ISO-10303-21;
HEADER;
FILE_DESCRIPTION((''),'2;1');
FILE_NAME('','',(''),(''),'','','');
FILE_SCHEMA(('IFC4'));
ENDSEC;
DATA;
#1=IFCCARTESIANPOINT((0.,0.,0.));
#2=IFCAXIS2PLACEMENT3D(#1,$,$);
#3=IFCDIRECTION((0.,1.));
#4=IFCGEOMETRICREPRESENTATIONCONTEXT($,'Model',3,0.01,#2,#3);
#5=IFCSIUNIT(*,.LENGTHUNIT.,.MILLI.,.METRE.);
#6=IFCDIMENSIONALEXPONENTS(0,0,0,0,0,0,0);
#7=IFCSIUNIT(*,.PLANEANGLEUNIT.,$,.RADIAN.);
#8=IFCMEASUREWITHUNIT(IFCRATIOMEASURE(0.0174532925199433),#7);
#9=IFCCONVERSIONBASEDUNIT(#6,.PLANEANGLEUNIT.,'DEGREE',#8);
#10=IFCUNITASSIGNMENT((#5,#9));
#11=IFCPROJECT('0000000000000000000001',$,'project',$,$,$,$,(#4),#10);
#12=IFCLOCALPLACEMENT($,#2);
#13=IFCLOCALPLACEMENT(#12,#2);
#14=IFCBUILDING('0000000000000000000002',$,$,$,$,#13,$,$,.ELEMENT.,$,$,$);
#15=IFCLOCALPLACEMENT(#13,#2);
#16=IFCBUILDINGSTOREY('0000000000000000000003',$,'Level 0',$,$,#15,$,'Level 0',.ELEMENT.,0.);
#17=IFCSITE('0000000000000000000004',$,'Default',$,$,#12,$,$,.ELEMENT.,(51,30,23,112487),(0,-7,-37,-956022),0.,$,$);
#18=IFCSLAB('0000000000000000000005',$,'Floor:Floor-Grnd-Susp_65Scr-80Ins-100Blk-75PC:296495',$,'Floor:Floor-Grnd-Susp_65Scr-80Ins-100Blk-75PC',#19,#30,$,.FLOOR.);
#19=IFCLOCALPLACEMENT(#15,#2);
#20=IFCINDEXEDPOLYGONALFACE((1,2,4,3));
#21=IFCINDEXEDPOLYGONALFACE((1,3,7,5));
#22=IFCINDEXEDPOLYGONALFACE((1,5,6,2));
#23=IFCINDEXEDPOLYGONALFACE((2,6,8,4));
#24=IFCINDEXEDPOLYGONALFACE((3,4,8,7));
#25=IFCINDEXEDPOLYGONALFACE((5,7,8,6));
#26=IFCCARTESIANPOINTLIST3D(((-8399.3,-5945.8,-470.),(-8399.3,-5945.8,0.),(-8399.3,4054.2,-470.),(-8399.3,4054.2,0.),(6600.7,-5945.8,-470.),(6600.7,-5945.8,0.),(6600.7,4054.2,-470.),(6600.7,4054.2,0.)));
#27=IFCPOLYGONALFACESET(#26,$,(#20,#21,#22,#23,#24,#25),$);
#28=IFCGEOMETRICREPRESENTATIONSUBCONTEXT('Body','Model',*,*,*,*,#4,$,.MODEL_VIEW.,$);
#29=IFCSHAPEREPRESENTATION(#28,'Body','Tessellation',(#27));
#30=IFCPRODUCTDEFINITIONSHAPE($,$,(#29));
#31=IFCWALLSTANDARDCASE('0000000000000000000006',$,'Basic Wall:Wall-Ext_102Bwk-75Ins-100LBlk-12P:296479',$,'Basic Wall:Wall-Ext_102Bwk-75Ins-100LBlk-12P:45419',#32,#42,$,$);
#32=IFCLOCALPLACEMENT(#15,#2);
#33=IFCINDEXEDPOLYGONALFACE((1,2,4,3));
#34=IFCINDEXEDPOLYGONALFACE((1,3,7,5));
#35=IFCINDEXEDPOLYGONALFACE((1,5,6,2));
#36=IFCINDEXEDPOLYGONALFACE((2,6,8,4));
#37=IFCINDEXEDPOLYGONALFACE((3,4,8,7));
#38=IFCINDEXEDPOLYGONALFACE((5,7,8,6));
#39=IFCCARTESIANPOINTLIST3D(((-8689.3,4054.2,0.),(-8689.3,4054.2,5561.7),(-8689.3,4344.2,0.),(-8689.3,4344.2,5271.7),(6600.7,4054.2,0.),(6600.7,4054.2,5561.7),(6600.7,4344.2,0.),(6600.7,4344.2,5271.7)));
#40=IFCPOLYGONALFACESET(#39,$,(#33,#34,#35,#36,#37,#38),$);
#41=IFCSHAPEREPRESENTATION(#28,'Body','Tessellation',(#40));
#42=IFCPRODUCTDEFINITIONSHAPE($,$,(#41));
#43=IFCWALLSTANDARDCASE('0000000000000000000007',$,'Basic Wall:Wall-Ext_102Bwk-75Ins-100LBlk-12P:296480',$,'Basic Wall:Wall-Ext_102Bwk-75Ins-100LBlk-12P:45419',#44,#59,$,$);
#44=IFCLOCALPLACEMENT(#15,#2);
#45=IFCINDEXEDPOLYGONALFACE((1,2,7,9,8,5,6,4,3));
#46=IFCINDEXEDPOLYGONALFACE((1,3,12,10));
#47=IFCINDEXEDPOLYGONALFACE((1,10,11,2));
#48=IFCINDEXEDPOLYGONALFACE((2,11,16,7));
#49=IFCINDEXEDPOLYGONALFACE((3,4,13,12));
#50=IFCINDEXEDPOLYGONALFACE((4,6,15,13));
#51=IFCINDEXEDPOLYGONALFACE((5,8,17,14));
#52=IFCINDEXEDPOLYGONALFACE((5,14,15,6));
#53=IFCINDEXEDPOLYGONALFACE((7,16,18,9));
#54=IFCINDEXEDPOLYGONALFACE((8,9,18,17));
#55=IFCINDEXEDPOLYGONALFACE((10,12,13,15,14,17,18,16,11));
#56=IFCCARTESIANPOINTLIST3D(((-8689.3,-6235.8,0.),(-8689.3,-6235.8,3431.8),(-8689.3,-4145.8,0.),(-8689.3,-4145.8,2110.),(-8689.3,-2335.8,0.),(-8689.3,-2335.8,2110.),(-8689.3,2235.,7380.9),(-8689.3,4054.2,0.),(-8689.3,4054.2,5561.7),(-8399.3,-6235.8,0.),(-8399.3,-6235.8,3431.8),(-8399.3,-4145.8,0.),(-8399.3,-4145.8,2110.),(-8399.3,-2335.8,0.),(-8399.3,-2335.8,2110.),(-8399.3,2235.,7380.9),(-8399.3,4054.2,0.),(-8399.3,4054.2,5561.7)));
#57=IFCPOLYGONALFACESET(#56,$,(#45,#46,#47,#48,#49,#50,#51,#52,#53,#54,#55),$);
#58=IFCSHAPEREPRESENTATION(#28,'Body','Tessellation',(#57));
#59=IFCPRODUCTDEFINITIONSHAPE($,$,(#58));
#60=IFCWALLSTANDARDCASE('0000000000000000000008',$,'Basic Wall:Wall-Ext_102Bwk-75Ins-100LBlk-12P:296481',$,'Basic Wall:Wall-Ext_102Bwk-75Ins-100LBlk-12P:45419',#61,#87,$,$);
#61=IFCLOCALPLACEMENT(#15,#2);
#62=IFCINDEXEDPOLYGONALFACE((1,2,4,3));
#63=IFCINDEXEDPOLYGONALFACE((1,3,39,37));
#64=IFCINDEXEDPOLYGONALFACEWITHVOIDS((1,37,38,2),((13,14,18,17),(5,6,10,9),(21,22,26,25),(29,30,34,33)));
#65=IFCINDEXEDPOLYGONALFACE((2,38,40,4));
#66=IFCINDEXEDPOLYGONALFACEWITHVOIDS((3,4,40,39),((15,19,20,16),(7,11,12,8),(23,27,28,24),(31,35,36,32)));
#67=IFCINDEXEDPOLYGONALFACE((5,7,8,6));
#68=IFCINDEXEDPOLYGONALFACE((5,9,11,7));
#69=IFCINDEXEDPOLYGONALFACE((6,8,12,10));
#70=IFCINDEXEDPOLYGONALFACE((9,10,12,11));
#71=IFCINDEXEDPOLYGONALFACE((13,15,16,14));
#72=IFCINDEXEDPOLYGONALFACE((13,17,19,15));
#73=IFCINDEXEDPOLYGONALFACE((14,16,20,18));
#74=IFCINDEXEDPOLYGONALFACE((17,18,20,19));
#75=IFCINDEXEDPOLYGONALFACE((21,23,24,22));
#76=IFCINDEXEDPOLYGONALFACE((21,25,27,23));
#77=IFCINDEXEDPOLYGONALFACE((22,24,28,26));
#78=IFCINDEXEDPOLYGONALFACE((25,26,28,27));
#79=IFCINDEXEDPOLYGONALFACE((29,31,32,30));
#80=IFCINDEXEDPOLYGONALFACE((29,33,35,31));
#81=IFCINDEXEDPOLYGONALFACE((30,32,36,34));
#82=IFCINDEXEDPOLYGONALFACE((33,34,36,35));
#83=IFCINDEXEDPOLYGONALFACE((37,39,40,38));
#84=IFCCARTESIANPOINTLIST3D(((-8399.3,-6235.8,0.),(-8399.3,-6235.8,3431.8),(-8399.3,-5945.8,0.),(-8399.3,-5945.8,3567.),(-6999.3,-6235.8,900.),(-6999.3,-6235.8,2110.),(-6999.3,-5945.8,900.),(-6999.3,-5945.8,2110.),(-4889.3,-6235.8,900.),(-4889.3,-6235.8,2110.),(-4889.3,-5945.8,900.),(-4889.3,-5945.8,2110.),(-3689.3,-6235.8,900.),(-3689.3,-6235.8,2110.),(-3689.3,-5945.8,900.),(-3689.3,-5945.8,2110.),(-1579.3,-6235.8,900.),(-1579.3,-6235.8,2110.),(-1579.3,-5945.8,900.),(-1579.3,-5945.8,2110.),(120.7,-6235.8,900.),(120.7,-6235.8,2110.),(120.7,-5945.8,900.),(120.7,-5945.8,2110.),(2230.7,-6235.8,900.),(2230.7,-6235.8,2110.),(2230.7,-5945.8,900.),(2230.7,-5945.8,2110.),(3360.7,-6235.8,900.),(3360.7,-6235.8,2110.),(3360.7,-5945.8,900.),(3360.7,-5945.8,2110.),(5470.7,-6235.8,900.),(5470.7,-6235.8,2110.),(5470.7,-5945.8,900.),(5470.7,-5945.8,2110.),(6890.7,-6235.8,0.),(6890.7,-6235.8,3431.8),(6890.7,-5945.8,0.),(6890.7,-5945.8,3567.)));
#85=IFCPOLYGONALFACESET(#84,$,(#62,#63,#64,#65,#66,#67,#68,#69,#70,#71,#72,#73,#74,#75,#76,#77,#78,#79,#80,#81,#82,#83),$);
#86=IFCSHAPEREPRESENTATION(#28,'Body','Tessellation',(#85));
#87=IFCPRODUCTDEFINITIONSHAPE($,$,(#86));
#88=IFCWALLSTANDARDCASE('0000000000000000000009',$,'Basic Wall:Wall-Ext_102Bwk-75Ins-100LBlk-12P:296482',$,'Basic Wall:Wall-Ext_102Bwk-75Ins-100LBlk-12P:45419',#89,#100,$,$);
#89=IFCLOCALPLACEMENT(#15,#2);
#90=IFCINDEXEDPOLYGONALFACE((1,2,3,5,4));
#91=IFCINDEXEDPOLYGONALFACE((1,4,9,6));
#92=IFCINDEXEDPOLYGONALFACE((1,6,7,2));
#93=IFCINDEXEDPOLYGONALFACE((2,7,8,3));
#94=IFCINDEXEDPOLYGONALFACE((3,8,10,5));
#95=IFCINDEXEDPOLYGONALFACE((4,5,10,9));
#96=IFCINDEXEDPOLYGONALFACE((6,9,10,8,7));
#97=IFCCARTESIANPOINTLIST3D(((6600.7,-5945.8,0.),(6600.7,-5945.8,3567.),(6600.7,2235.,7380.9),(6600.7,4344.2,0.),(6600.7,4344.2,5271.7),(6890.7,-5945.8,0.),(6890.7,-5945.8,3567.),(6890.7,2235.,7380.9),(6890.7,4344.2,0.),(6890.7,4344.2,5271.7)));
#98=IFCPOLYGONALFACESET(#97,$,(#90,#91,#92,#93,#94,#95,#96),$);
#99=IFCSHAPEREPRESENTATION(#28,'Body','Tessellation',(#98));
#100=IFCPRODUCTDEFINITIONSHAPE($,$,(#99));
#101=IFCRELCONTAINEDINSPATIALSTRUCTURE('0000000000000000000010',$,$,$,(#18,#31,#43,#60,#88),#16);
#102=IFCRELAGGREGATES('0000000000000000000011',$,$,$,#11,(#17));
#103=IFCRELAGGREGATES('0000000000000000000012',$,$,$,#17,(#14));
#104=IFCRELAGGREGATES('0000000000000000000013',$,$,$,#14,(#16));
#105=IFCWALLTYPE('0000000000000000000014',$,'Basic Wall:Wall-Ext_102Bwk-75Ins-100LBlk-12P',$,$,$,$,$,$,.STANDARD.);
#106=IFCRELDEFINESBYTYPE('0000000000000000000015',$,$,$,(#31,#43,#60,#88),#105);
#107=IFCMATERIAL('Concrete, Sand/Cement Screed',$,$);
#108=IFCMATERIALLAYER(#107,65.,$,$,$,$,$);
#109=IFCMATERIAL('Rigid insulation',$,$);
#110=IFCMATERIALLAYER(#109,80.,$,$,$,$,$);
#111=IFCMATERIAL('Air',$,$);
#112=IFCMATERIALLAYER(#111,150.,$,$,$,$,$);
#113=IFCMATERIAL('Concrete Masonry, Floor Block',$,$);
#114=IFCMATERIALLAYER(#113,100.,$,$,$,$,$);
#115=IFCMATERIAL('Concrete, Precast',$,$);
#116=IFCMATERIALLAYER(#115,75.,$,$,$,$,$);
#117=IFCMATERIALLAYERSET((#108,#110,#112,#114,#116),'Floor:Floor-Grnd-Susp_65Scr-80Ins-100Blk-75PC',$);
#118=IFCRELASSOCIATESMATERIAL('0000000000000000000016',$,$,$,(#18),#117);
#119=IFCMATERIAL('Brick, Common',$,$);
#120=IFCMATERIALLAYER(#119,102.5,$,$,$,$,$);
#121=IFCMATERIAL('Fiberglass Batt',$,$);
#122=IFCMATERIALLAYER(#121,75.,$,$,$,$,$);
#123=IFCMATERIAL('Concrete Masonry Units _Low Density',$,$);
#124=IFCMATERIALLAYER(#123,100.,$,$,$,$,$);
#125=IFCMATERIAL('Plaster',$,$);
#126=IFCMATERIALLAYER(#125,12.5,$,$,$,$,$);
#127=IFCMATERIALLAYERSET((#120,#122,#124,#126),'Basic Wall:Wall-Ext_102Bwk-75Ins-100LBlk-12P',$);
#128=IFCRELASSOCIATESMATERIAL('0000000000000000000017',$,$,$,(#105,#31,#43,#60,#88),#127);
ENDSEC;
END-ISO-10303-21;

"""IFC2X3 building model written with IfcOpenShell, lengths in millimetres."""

from ifc_helpers import new_model, entity, si_unit, converted_unit, direction, frame, frame_2d, origin, place, context, subcontext, project, spatial, polyline, rectangle, extrude, clip, bounded_halfspace, material, layer, layer_set, layer_usage, type_object, element, save


model = new_model("IFC2X3")

# Units and contexts
model_context = context("Model", 3, precision=0.01, world=origin(), true_north=direction((0.0, 1.0)))
body_context = subcontext(model_context, "Body", "Model", "MODEL_VIEW")
ifc_project = project(units=[si_unit("LENGTHUNIT", "METRE", prefix="MILLI"), converted_unit("PLANEANGLEUNIT", "DEGREE", entity("IfcRatioMeasure", 0.0174532925199433), si_unit("PLANEANGLEUNIT", "RADIAN"), dimensions=[0, 0, 0, 0, 0, 0, 0])], contexts=[model_context])

# Site, building, storey
site_placement = place(None, origin())
site = spatial("IfcSite", under=ifc_project, at=site_placement, Name="Default", CompositionType="ELEMENT", RefLatitude=(51, 30, 23, 112487), RefLongitude=(0, -7, -37, -956022), RefElevation=0.0)
building_placement = place(site_placement, origin())
building = spatial("IfcBuilding", under=site, at=building_placement, CompositionType="ELEMENT")
storey_placement = place(building_placement, origin())
storey = spatial("IfcBuildingStorey", under=building, at=storey_placement, Name="Level 0", LongName="Level 0", CompositionType="ELEMENT", Elevation=0.0)

# Slab
ifc_material_1 = material(Name="Concrete, Sand/Cement Screed")
ifc_layer_1 = layer(ifc_material_1, 65.0)
ifc_material_2 = material(Name="Rigid insulation")
ifc_layer_2 = layer(ifc_material_2, 80.0)
ifc_material_3 = material(Name="Air")
ifc_layer_3 = layer(ifc_material_3, 150.0)
ifc_material_4 = material(Name="Concrete Masonry, Floor Block")
ifc_layer_4 = layer(ifc_material_4, 100.0)
ifc_material_5 = material(Name="Concrete, Precast")
ifc_layer_5 = layer(ifc_material_5, 75.0)
ifc_layer_set_1 = layer_set([ifc_layer_1, ifc_layer_2, ifc_layer_3, ifc_layer_4, ifc_layer_5], Name="Floor:Floor-Grnd-Susp_65Scr-80Ins-100Blk-75PC")
ifc_layer_usage_1 = layer_usage(ifc_layer_set_1, "AXIS3", "POSITIVE", 0.0)
slab_placement = place(storey_placement, origin())
element("IfcSlab", 1, at=slab_placement, inside=storey, material=ifc_layer_usage_1, Name="Floor:Floor-Grnd-Susp_65Scr-80Ins-100Blk-75PC:296495", ObjectType="Floor:Floor-Grnd-Susp_65Scr-80Ins-100Blk-75PC", PredefinedType="FLOOR", context=body_context, shape_type="SweptSolid", body=[
    extrude(rectangle(XDim=10000.0, YDim=15000.0, at=frame_2d((0.0, 0.0), x_axis=(1.0, 0.0))), frame((-899.3, -945.8, 0.0), z_axis=(0.0, 0.0, -1.0), x_axis=(0.0, 1.0, 0.0)), (0.0, 0.0, 1.0), 470.0),
])

# Wall
ifc_material_6 = material(Name="Brick, Common")
ifc_layer_6 = layer(ifc_material_6, 102.5)
ifc_material_7 = material(Name="Fiberglass Batt")
ifc_layer_7 = layer(ifc_material_7, 75.0)
ifc_material_8 = material(Name="Concrete Masonry Units _Low Density")
ifc_layer_8 = layer(ifc_material_8, 100.0)
ifc_material_9 = material(Name="Plaster")
ifc_layer_9 = layer(ifc_material_9, 12.5)
ifc_layer_set_2 = layer_set([ifc_layer_6, ifc_layer_7, ifc_layer_8, ifc_layer_9], Name="Basic Wall:Wall-Ext_102Bwk-75Ins-100LBlk-12P")
ifc_layer_usage_2 = layer_usage(ifc_layer_set_2, "AXIS2", "NEGATIVE", 145.0)
wall_type = type_object("IfcWallType", Name="Basic Wall:Wall-Ext_102Bwk-75Ins-100LBlk-12P", PredefinedType="STANDARD", material=ifc_layer_set_2)
wall_1_placement = place(storey_placement, frame((-8689.3, 4199.2, 0.0)))
element("IfcWallStandardCase", 2, at=wall_1_placement, inside=storey, type_object=wall_type, material=ifc_layer_usage_2, Name="Basic Wall:Wall-Ext_102Bwk-75Ins-100LBlk-12P:296479", ObjectType="Basic Wall:Wall-Ext_102Bwk-75Ins-100LBlk-12P:45419", context=body_context, shape_type="Clipping", body=[
    clip(extrude(rectangle(XDim=15290.0, YDim=290.0, at=frame_2d((7645.0, 0.0), x_axis=(-1.0, 0.0))), origin(), (0.0, 0.0, 1.0), 5561.7), bounded_halfspace(frame((0.0, -145.0, 5561.7), z_axis=(0.0, -0.707107, -0.707107), x_axis=(-1.0, 0.0, 0.0)), True, frame((0.0, -145.0, 5561.7)), polyline([(0.0, 0.0), (290.0, 0.0), (15290.0, 0.0), (15290.0, 290.0), (0.0, 290.0), (0.0, 0.0)]))),
])

# Wall, opening
ifc_layer_usage_3 = layer_usage(ifc_layer_set_2, "AXIS2", "NEGATIVE", 145.0)
wall_2_placement = place(storey_placement, frame((-8544.3, -6235.8, 0.0), z_axis=(0.0, 0.0, 1.0), x_axis=(0.0, 1.0, 0.0)))
wall_2 = element("IfcWallStandardCase", 3, at=wall_2_placement, inside=storey, type_object=wall_type, material=ifc_layer_usage_3, Name="Basic Wall:Wall-Ext_102Bwk-75Ins-100LBlk-12P:296480", ObjectType="Basic Wall:Wall-Ext_102Bwk-75Ins-100LBlk-12P:45419", context=body_context, shape_type="Clipping", body=[
    clip(clip(extrude(rectangle(XDim=10290.0, YDim=290.0, at=frame_2d((5145.0, 0.0), x_axis=(-1.0, 0.0))), origin(), (0.0, 0.0, 1.0), 7380.9), bounded_halfspace(frame((0.0, -145.0, 3431.8), z_axis=(0.422538, 0.0, -0.906345), x_axis=(0.0, 1.0, 0.0)), True, frame((0.0, -145.0, 3431.8)), polyline([(0.0, 0.0), (290.0, 0.0), (8470.8, 0.0), (8470.8, 290.0), (0.0, 290.0), (0.0, 0.0)]))), bounded_halfspace(frame((8470.8, -145.0, 7380.9), z_axis=(-0.707107, 0.0, -0.707107), x_axis=(0.0, 1.0, 0.0)), True, frame((8470.8, -145.0, 7380.9)), polyline([(0.0, 0.0), (1819.2, 0.0), (1819.2, 290.0), (0.0, 290.0), (0.0, 0.0)]))),
])
opening_1_placement = place(wall_2_placement, frame((3900.0, 145.0, 0.0)))
element("IfcOpeningElement", 4, at=opening_1_placement, cuts=wall_2, ObjectType="Opening", context=body_context, shape_type="SweptSolid", body=[
    extrude(rectangle(XDim=2110.0, YDim=1810.0, at=frame_2d((1055.0, 905.0), x_axis=(-1.0, 0.0))), frame((0.0, 0.0, 0.0), z_axis=(0.0, -1.0, 0.0), x_axis=(0.0, 0.0, 1.0)), (0.0, 0.0, 1.0), 290.0),
])

# Wall, openings
ifc_layer_usage_4 = layer_usage(ifc_layer_set_2, "AXIS2", "NEGATIVE", 145.0)
wall_3_placement = place(storey_placement, frame((6890.7, -6090.8, 0.0), z_axis=(0.0, 0.0, 1.0), x_axis=(-1.0, 0.0, 0.0)))
wall_3 = element("IfcWallStandardCase", 5, at=wall_3_placement, inside=storey, type_object=wall_type, material=ifc_layer_usage_4, Name="Basic Wall:Wall-Ext_102Bwk-75Ins-100LBlk-12P:296481", ObjectType="Basic Wall:Wall-Ext_102Bwk-75Ins-100LBlk-12P:45419", context=body_context, shape_type="Clipping", body=[
    clip(extrude(rectangle(XDim=15290.0, YDim=290.0, at=frame_2d((7645.0, 0.0), x_axis=(-1.0, 0.0))), origin(), (0.0, 0.0, 1.0), 3567.0), bounded_halfspace(frame((0.0, -145.0, 3567.0), z_axis=(0.0, -0.422538, -0.906345), x_axis=(1.0, 0.0, 0.0)), True, frame((0.0, -145.0, 3567.0)), polyline([(0.0, 0.0), (290.0, 0.0), (15290.0, 0.0), (15290.0, 290.0), (0.0, 290.0), (0.0, 0.0)]))),
])
opening_2_placement = place(wall_3_placement, frame((11780.0, -145.0, 900.0)))
element("IfcOpeningElement", 6, at=opening_2_placement, cuts=wall_3, ObjectType="Opening", context=body_context, shape_type="SweptSolid", body=[
    extrude(rectangle(XDim=1210.0, YDim=2110.0, at=frame_2d((605.0, 1055.0), x_axis=(-1.0, 0.0))), frame((0.0, 0.0, 0.0), z_axis=(0.0, 1.0, 0.0), x_axis=(0.0, 0.0, 1.0)), (0.0, 0.0, 1.0), 290.0),
])
opening_3_placement = place(wall_3_placement, frame((10580.0, 145.0, 900.0)))
element("IfcOpeningElement", 7, at=opening_3_placement, cuts=wall_3, ObjectType="Opening", context=body_context, shape_type="SweptSolid", body=[
    extrude(rectangle(XDim=1210.0, YDim=2110.0, at=frame_2d((605.0, 1055.0), x_axis=(-1.0, 0.0))), frame((0.0, 0.0, 0.0), z_axis=(0.0, -1.0, 0.0), x_axis=(0.0, 0.0, 1.0)), (0.0, 0.0, 1.0), 290.0),
])
opening_4_placement = place(wall_3_placement, frame((6770.0, 145.0, 900.0)))
element("IfcOpeningElement", 8, at=opening_4_placement, cuts=wall_3, ObjectType="Opening", context=body_context, shape_type="SweptSolid", body=[
    extrude(rectangle(XDim=1210.0, YDim=2110.0, at=frame_2d((605.0, 1055.0), x_axis=(-1.0, 0.0))), frame((0.0, 0.0, 0.0), z_axis=(0.0, -1.0, 0.0), x_axis=(0.0, 0.0, 1.0)), (0.0, 0.0, 1.0), 290.0),
])
opening_5_placement = place(wall_3_placement, frame((3530.0, 145.0, 900.0)))
element("IfcOpeningElement", 9, at=opening_5_placement, cuts=wall_3, ObjectType="Opening", context=body_context, shape_type="SweptSolid", body=[
    extrude(rectangle(XDim=1210.0, YDim=2110.0, at=frame_2d((605.0, 1055.0), x_axis=(-1.0, 0.0))), frame((0.0, 0.0, 0.0), z_axis=(0.0, -1.0, 0.0), x_axis=(0.0, 0.0, 1.0)), (0.0, 0.0, 1.0), 290.0),
])

# Wall
ifc_layer_usage_5 = layer_usage(ifc_layer_set_2, "AXIS2", "NEGATIVE", 145.0)
wall_4_placement = place(storey_placement, frame((6745.7, 4344.2, 0.0), z_axis=(0.0, 0.0, 1.0), x_axis=(0.0, -1.0, 0.0)))
element("IfcWallStandardCase", 10, at=wall_4_placement, inside=storey, type_object=wall_type, material=ifc_layer_usage_5, Name="Basic Wall:Wall-Ext_102Bwk-75Ins-100LBlk-12P:296482", ObjectType="Basic Wall:Wall-Ext_102Bwk-75Ins-100LBlk-12P:45419", context=body_context, shape_type="Clipping", body=[
    clip(clip(extrude(rectangle(XDim=10290.0, YDim=290.0, at=frame_2d((5145.0, 0.0), x_axis=(-1.0, 0.0))), origin(), (0.0, 0.0, 1.0), 7380.9), bounded_halfspace(frame((2109.2, -145.0, 7380.9), z_axis=(-0.422538, 0.0, -0.906345), x_axis=(0.0, -1.0, 0.0)), True, frame((2109.2, -145.0, 7380.9)), polyline([(0.0, 0.0), (8180.8, 0.0), (8180.8, 290.0), (0.0, 290.0), (0.0, 0.0)]))), bounded_halfspace(frame((0.0, -145.0, 5271.7), z_axis=(0.707107, 0.0, -0.707107), x_axis=(0.0, -1.0, 0.0)), True, frame((0.0, -145.0, 5271.7)), polyline([(0.0, 0.0), (290.0, 0.0), (2109.2, 0.0), (2109.2, 290.0), (0.0, 290.0), (0.0, 0.0)]))),
])

save(model, "model.ifc")
